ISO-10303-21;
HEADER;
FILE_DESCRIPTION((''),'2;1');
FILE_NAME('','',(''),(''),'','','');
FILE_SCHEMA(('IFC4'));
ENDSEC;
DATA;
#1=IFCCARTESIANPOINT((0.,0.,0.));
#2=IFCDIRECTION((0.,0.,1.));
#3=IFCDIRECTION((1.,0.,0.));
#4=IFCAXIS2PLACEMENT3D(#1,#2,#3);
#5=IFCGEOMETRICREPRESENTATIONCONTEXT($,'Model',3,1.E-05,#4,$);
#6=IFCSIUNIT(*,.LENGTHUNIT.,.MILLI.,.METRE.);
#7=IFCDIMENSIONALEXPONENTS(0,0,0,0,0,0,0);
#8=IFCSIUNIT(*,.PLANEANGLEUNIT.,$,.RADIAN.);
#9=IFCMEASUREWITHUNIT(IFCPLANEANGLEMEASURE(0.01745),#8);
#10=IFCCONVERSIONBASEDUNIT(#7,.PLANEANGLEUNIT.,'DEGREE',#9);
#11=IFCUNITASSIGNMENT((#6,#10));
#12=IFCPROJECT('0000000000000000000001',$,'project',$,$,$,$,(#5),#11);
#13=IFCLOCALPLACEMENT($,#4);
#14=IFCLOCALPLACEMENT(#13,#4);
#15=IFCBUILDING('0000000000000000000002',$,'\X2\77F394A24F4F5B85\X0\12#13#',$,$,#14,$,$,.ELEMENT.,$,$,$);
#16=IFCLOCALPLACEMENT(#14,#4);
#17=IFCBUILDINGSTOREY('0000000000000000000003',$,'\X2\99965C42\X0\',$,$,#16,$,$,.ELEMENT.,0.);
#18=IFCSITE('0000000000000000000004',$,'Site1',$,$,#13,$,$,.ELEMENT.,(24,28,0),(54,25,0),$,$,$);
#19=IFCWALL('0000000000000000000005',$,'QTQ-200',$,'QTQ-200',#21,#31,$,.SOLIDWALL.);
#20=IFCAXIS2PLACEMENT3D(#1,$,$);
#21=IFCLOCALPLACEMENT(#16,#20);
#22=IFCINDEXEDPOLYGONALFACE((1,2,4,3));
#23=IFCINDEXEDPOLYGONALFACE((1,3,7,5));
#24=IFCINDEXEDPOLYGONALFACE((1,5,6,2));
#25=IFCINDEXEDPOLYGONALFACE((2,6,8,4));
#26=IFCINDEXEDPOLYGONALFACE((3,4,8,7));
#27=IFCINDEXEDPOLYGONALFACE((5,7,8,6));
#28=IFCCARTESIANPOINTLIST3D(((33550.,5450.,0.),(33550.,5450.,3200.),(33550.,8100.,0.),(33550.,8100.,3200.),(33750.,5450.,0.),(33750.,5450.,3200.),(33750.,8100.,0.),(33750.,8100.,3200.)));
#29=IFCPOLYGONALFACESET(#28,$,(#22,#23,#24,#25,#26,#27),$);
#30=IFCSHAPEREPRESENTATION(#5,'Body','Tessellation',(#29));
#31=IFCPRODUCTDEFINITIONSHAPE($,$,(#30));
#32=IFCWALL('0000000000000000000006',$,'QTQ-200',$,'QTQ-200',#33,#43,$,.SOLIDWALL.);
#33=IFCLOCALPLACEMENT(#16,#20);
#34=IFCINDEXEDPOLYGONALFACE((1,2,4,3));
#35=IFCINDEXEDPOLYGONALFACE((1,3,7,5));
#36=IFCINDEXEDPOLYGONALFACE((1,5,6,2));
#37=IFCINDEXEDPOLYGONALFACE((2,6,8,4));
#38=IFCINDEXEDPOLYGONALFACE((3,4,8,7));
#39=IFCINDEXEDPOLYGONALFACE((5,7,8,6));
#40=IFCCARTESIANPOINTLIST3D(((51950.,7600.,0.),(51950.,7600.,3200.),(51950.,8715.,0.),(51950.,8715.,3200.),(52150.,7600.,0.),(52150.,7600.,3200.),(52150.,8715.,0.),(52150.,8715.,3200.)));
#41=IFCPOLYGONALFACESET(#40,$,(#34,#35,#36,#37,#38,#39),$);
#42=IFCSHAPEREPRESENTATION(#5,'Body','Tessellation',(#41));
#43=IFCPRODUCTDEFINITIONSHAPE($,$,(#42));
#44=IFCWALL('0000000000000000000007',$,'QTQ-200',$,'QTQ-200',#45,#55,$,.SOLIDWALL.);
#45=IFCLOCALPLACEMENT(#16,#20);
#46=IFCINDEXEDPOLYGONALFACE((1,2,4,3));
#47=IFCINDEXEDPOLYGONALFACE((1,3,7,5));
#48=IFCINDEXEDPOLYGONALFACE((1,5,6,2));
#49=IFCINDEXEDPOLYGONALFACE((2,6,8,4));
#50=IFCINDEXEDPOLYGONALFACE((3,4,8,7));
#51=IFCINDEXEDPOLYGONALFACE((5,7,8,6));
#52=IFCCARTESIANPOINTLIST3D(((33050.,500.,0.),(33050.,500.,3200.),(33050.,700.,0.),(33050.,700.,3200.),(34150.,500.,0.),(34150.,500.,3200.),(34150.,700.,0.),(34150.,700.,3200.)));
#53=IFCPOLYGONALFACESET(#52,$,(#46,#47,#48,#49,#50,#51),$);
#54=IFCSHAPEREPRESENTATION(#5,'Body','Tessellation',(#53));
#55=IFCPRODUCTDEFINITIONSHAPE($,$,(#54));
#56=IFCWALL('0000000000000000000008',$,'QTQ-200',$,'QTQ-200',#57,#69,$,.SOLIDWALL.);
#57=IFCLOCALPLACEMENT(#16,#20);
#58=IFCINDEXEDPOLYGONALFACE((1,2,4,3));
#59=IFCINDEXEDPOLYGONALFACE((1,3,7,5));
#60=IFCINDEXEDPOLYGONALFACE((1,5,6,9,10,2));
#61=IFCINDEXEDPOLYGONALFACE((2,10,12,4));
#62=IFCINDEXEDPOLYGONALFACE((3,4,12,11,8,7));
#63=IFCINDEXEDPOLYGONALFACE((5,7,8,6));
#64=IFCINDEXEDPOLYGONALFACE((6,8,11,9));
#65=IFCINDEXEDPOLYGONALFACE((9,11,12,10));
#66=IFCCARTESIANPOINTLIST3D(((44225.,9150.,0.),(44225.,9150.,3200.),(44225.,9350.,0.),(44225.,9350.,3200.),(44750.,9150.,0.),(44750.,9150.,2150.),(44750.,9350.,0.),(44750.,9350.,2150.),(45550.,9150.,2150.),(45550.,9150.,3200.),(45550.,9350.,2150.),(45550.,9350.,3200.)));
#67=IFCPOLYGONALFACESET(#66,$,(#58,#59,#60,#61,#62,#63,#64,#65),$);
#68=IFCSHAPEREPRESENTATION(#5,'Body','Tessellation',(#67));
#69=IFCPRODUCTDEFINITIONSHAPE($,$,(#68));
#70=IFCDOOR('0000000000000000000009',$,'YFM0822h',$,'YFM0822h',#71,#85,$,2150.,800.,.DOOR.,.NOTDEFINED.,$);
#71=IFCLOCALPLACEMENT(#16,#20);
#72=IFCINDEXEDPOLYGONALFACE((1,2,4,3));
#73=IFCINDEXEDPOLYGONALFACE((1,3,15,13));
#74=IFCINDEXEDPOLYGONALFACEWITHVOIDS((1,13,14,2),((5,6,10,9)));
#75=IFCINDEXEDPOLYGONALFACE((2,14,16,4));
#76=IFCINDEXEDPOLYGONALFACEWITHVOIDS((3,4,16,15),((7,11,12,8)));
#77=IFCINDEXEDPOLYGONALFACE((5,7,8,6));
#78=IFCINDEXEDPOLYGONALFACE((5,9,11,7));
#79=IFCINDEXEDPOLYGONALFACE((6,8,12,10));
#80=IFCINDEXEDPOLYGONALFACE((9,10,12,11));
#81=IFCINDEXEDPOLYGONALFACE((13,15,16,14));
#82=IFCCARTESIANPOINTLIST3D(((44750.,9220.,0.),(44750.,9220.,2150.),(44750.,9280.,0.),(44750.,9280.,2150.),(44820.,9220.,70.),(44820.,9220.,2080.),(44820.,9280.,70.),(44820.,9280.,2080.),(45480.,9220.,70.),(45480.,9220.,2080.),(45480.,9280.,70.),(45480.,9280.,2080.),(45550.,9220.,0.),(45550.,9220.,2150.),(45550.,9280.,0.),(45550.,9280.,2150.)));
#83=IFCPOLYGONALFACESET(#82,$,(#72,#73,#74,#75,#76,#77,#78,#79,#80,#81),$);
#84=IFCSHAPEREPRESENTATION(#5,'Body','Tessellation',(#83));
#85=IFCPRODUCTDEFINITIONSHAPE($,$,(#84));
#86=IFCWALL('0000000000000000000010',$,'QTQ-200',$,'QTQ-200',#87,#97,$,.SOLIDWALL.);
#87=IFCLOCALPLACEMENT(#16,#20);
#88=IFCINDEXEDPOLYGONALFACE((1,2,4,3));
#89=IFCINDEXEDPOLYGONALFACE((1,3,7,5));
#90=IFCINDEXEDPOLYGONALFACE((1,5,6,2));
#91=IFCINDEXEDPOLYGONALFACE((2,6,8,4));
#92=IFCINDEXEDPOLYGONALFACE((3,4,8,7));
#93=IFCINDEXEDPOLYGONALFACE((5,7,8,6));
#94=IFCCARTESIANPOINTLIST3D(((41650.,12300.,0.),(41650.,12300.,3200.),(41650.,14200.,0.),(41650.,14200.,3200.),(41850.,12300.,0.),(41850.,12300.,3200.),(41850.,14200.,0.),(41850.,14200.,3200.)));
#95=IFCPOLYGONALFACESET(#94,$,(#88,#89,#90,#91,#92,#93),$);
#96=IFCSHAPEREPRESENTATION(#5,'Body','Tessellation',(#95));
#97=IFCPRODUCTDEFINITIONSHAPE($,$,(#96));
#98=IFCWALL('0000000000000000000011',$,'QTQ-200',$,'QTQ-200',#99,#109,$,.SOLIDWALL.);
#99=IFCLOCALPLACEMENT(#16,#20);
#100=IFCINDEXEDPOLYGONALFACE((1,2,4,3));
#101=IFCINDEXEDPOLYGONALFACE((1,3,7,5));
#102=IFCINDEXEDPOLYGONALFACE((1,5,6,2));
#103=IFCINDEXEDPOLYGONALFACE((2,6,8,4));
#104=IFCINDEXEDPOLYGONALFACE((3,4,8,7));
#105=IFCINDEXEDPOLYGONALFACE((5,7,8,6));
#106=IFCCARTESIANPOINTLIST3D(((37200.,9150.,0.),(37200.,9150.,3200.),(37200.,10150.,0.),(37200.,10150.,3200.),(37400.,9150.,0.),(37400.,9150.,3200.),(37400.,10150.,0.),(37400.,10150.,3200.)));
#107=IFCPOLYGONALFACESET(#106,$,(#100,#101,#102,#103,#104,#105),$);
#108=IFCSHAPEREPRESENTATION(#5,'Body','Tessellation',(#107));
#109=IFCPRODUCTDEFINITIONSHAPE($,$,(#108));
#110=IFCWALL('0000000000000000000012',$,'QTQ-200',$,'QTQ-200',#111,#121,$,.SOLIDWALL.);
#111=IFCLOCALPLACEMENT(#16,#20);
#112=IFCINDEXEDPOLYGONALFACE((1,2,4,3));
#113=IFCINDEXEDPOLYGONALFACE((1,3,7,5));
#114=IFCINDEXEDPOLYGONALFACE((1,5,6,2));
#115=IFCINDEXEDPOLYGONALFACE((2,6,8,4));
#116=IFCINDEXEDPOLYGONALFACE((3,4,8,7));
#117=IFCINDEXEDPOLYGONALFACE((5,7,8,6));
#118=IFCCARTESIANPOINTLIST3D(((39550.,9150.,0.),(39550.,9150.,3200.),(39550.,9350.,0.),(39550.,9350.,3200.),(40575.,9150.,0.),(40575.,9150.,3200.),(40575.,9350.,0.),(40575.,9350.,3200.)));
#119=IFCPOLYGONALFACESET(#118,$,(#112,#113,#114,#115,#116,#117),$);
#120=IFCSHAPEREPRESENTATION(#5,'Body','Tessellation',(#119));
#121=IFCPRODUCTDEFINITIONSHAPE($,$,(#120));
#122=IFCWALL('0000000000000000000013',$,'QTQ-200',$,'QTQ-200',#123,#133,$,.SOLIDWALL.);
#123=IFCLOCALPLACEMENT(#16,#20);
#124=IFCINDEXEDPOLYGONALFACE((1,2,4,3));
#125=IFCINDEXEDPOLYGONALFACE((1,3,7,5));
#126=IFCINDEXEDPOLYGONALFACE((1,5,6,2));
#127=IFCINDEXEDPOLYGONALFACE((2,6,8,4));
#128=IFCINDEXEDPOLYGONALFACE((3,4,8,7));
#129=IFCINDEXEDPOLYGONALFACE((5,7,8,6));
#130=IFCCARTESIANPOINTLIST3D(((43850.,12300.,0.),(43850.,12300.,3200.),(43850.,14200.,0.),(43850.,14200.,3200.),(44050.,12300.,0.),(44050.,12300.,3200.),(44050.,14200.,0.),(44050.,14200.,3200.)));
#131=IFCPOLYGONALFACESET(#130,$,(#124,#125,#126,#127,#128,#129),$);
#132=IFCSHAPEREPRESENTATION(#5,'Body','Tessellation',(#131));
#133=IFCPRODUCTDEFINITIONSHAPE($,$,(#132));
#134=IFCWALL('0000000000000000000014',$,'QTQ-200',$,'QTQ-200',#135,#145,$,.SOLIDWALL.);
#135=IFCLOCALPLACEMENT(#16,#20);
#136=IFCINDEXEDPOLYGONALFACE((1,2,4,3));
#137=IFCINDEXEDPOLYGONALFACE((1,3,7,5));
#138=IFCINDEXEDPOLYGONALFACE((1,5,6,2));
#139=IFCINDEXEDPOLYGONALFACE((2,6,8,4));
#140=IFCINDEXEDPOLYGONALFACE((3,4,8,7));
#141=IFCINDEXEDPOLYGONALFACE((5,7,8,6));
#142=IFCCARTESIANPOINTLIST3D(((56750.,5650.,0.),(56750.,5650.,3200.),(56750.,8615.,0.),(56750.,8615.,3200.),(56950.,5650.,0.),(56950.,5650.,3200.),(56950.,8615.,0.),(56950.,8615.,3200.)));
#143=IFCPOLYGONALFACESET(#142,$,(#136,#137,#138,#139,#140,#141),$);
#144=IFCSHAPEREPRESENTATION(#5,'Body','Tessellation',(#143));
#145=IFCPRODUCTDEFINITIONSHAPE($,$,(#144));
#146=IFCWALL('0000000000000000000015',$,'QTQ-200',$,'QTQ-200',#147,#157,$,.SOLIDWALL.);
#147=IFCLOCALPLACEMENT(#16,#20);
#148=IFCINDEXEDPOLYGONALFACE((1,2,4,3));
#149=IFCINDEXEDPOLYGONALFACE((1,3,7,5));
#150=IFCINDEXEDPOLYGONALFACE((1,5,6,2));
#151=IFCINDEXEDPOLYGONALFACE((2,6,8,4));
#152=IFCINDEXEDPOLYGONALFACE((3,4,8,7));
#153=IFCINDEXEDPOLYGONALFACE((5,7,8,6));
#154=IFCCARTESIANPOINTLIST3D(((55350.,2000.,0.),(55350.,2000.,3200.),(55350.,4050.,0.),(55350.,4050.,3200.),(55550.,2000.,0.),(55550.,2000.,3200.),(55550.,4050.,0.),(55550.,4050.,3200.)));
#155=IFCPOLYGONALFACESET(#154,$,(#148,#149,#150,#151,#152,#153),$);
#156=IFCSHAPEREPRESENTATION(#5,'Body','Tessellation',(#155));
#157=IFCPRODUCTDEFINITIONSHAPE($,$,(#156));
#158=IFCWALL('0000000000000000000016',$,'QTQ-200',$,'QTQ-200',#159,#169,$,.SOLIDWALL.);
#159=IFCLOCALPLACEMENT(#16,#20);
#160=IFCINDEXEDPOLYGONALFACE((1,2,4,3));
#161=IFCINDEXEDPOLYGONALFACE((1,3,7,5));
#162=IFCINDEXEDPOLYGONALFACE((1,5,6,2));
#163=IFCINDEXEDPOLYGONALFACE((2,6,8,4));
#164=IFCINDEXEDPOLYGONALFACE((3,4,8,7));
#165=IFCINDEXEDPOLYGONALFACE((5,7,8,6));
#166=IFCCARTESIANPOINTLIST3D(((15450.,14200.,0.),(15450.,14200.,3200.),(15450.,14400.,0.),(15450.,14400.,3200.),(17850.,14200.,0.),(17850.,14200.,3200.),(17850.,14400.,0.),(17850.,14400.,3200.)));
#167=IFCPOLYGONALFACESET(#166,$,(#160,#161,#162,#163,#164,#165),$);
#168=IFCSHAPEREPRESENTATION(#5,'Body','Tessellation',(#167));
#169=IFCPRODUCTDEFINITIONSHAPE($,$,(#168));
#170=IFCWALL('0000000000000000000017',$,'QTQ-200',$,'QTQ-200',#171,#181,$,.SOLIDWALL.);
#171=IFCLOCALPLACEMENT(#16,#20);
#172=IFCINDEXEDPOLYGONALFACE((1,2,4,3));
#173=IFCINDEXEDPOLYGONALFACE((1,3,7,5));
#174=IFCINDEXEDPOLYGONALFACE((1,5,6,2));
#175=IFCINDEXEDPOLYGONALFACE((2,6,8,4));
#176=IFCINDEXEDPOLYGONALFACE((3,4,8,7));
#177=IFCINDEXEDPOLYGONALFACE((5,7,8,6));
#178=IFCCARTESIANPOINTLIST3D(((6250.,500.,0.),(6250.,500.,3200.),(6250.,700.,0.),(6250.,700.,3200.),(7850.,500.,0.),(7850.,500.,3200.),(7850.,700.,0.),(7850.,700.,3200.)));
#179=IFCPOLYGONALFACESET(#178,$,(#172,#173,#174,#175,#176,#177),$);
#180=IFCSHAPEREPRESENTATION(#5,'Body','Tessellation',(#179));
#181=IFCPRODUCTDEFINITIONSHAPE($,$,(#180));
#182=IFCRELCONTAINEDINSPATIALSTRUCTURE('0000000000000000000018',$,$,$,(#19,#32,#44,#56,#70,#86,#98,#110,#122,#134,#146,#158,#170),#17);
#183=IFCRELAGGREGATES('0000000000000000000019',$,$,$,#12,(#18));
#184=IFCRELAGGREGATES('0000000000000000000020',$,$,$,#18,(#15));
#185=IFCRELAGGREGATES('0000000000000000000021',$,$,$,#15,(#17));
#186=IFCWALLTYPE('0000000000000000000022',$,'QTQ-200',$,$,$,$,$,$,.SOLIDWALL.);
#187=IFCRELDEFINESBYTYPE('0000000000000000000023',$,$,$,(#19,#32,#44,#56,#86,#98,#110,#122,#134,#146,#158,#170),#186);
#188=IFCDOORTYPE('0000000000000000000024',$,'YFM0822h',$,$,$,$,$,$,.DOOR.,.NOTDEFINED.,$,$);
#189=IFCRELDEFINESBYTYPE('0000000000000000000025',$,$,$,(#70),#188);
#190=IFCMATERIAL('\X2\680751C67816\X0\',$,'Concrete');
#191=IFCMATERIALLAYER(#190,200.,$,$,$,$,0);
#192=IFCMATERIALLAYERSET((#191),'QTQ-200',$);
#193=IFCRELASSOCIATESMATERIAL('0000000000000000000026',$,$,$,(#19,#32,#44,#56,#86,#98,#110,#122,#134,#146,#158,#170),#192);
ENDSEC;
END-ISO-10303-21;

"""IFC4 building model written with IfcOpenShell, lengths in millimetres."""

from ifc_helpers import new_model, entity, si_unit, converted_unit, frame, origin_with_axes, place, context, project, spatial, polyline, outline, extrude, material, layer, layer_set, type_object, element, fill, save


model = new_model("IFC4")

# Units and contexts
model_context = context("Model", 3, precision=1e-05, world=origin_with_axes())
ifc_project = project(units=[si_unit("LENGTHUNIT", "METRE", prefix="MILLI"), converted_unit("PLANEANGLEUNIT", "DEGREE", entity("IfcPlaneAngleMeasure", 0.01745), si_unit("PLANEANGLEUNIT", "RADIAN"), dimensions=[0, 0, 0, 0, 0, 0, 0])], contexts=[model_context])

# Site, building, storey
site_placement = place(None, origin_with_axes())
site = spatial("IfcSite", under=ifc_project, at=site_placement, Name="Site1", CompositionType="ELEMENT", RefLatitude=(24, 28, 0), RefLongitude=(54, 25, 0))
building_placement = place(site_placement, origin_with_axes())
building = spatial("IfcBuilding", under=site, at=building_placement, Name="石钢住宅12#13#", CompositionType="ELEMENT")
storey_placement = place(building_placement, origin_with_axes())
storey = spatial("IfcBuildingStorey", under=building, at=storey_placement, Name="首层", CompositionType="ELEMENT", Elevation=0.0)

# Walls
ifc_material = material(Name="标准砖", Category="Concrete")
ifc_layer = layer(ifc_material, 200.0, Priority=0)
ifc_layer_set = layer_set([ifc_layer], Name="QTQ-200")
wall_type = type_object("IfcWallType", Name="QTQ-200", PredefinedType="SOLIDWALL")
wall_1_placement = place(storey_placement, origin_with_axes())
element("IfcWall", 1, at=wall_1_placement, inside=storey, type_object=wall_type, material=ifc_layer_set, Name="QTQ-200", ObjectType="QTQ-200", PredefinedType="SOLIDWALL", context=model_context, shape_type="SweptSolid", body=[
    extrude(outline(polyline([(0.0, 0.0), (3200.0, 0.0), (3200.0, 2650.0), (0.0, 2650.0), (0.0, 0.0)])), frame((33750.0, 8100.0, 3200.0), z_axis=(-1.0, 0.0, 0.0), x_axis=(0.0, 0.0, -1.0)), (0.0, 0.0, 1.0), 200.0),
])
wall_2_placement = place(storey_placement, origin_with_axes())
element("IfcWall", 2, at=wall_2_placement, inside=storey, type_object=wall_type, material=ifc_layer_set, Name="QTQ-200", ObjectType="QTQ-200", PredefinedType="SOLIDWALL", context=model_context, shape_type="SweptSolid", body=[
    extrude(outline(polyline([(0.0, 0.0), (3200.0, 0.0), (3200.0, 1115.0), (0.0, 1115.0), (0.0, 0.0)])), frame((52150.0, 8715.0, 3200.0), z_axis=(-1.0, 0.0, 0.0), x_axis=(0.0, 0.0, -1.0)), (0.0, 0.0, 1.0), 200.0),
])
wall_3_placement = place(storey_placement, origin_with_axes())
element("IfcWall", 3, at=wall_3_placement, inside=storey, type_object=wall_type, material=ifc_layer_set, Name="QTQ-200", ObjectType="QTQ-200", PredefinedType="SOLIDWALL", context=model_context, shape_type="SweptSolid", body=[
    extrude(outline(polyline([(0.0, 0.0), (3200.0, 0.0), (3200.0, 1100.0), (0.0, 1100.0), (0.0, 0.0)])), frame((34150.0, 500.0, 3200.0), z_axis=(0.0, 1.0, 0.0), x_axis=(0.0, 0.0, -1.0)), (0.0, 0.0, 1.0), 200.0),
])

# Wall, opening, door
wall_4_placement = place(storey_placement, origin_with_axes())
wall_4 = element("IfcWall", 4, at=wall_4_placement, inside=storey, type_object=wall_type, material=ifc_layer_set, Name="QTQ-200", ObjectType="QTQ-200", PredefinedType="SOLIDWALL", context=model_context, shape_type="SweptSolid", body=[
    extrude(outline(polyline([(0.0, 0.0), (3200.0, 0.0), (3200.0, 1325.0), (0.0, 1325.0), (0.0, 0.0)])), frame((45550.0, 9150.0, 3200.0), z_axis=(0.0, 1.0, 0.0), x_axis=(0.0, 0.0, -1.0)), (0.0, 0.0, 1.0), 200.0),
])
opening_1_placement = place(storey_placement, origin_with_axes())
opening_1 = element("IfcOpeningElement", 5, at=opening_1_placement, cuts=wall_4, PredefinedType="OPENING", context=model_context, shape_type="SweptSolid", body=[
    extrude(outline(polyline([(0.0, 0.0), (800.0, 0.0), (800.0, 2150.0), (0.0, 2150.0), (0.0, 0.0)])), frame((45550.0, 8150.0, 0.0), z_axis=(0.0, 1.0, 0.0), x_axis=(-1.0, 0.0, 0.0)), (0.0, 0.0, 1.0), 2200.0),
])
door_type_1 = type_object("IfcDoorType", Name="YFM0822h", OperationType="NOTDEFINED", PredefinedType="DOOR")
door_1_placement = place(storey_placement, origin_with_axes())
door_1 = element("IfcDoor", 6, at=door_1_placement, inside=storey, type_object=door_type_1, Name="YFM0822h", ObjectType="YFM0822h", OperationType="NOTDEFINED", OverallHeight=2150.0, OverallWidth=800.0, PredefinedType="DOOR", context=model_context, shape_type="SweptSolid", body=[
    extrude(outline(polyline([(-400.0, -1075.0), (400.0, -1075.0), (400.0, 1075.0), (-400.0, 1075.0), (-400.0, -1075.0)]), holes=[polyline([(-330.0, -1005.0), (-330.0, 1005.0), (330.0, 1005.0), (330.0, -1005.0), (-330.0, -1005.0)])]), frame((45150.0, 9220.0, 1075.0), z_axis=(0.0, 1.0, 0.0), x_axis=(-1.0, 0.0, 0.0)), (0.0, 0.0, 1.0), 60.0),
])
fill(opening_1, door_1)

# Walls
wall_5_placement = place(storey_placement, origin_with_axes())
element("IfcWall", 7, at=wall_5_placement, inside=storey, type_object=wall_type, material=ifc_layer_set, Name="QTQ-200", ObjectType="QTQ-200", PredefinedType="SOLIDWALL", context=model_context, shape_type="SweptSolid", body=[
    extrude(outline(polyline([(0.0, 0.0), (3200.0, 0.0), (3200.0, 1900.0), (0.0, 1900.0), (0.0, 0.0)])), frame((41650.0, 12300.0, 3200.0), z_axis=(1.0, 0.0, 0.0), x_axis=(0.0, 0.0, -1.0)), (0.0, 0.0, 1.0), 200.0),
])
wall_6_placement = place(storey_placement, origin_with_axes())
element("IfcWall", 8, at=wall_6_placement, inside=storey, type_object=wall_type, material=ifc_layer_set, Name="QTQ-200", ObjectType="QTQ-200", PredefinedType="SOLIDWALL", context=model_context, shape_type="SweptSolid", body=[
    extrude(outline(polyline([(0.0, 0.0), (3200.0, 0.0), (3200.0, 1000.0), (0.0, 1000.0), (0.0, 0.0)])), frame((37400.0, 10150.0, 3200.0), z_axis=(-1.0, 0.0, 0.0), x_axis=(0.0, 0.0, -1.0)), (0.0, 0.0, 1.0), 200.0),
])
wall_7_placement = place(storey_placement, origin_with_axes())
element("IfcWall", 9, at=wall_7_placement, inside=storey, type_object=wall_type, material=ifc_layer_set, Name="QTQ-200", ObjectType="QTQ-200", PredefinedType="SOLIDWALL", context=model_context, shape_type="SweptSolid", body=[
    extrude(outline(polyline([(0.0, 0.0), (3200.0, 0.0), (3200.0, 1025.0), (0.0, 1025.0), (0.0, 0.0)])), frame((40575.0, 9150.0, 3200.0), z_axis=(0.0, 1.0, 0.0), x_axis=(0.0, 0.0, -1.0)), (0.0, 0.0, 1.0), 200.0),
])
wall_8_placement = place(storey_placement, origin_with_axes())
element("IfcWall", 10, at=wall_8_placement, inside=storey, type_object=wall_type, material=ifc_layer_set, Name="QTQ-200", ObjectType="QTQ-200", PredefinedType="SOLIDWALL", context=model_context, shape_type="SweptSolid", body=[
    extrude(outline(polyline([(0.0, 0.0), (3200.0, 0.0), (3200.0, 1900.0), (0.0, 1900.0), (0.0, 0.0)])), frame((43850.0, 12300.0, 3200.0), z_axis=(1.0, 0.0, 0.0), x_axis=(0.0, 0.0, -1.0)), (0.0, 0.0, 1.0), 200.0),
])
wall_9_placement = place(storey_placement, origin_with_axes())
element("IfcWall", 11, at=wall_9_placement, inside=storey, type_object=wall_type, material=ifc_layer_set, Name="QTQ-200", ObjectType="QTQ-200", PredefinedType="SOLIDWALL", context=model_context, shape_type="SweptSolid", body=[
    extrude(outline(polyline([(0.0, 0.0), (3200.0, 0.0), (3200.0, 2965.0), (0.0, 2965.0), (0.0, 0.0)])), frame((56950.0, 8615.0, 3200.0), z_axis=(-1.0, 0.0, 0.0), x_axis=(0.0, 0.0, -1.0)), (0.0, 0.0, 1.0), 200.0),
])
wall_10_placement = place(storey_placement, origin_with_axes())
element("IfcWall", 12, at=wall_10_placement, inside=storey, type_object=wall_type, material=ifc_layer_set, Name="QTQ-200", ObjectType="QTQ-200", PredefinedType="SOLIDWALL", context=model_context, shape_type="SweptSolid", body=[
    extrude(outline(polyline([(0.0, 0.0), (3200.0, 0.0), (3200.0, 2050.0), (0.0, 2050.0), (0.0, 0.0)])), frame((55350.0, 2000.0, 3200.0), z_axis=(1.0, 0.0, 0.0), x_axis=(0.0, 0.0, -1.0)), (0.0, 0.0, 1.0), 200.0),
])
wall_11_placement = place(storey_placement, origin_with_axes())
element("IfcWall", 13, at=wall_11_placement, inside=storey, type_object=wall_type, material=ifc_layer_set, Name="QTQ-200", ObjectType="QTQ-200", PredefinedType="SOLIDWALL", context=model_context, shape_type="SweptSolid", body=[
    extrude(outline(polyline([(0.0, 0.0), (3200.0, 0.0), (3200.0, 2400.0), (0.0, 2400.0), (0.0, 0.0)])), frame((15450.0, 14400.0, 3200.0), z_axis=(0.0, -1.0, 0.0), x_axis=(0.0, 0.0, -1.0)), (0.0, 0.0, 1.0), 200.0),
])
wall_12_placement = place(storey_placement, origin_with_axes())
element("IfcWall", 14, at=wall_12_placement, inside=storey, type_object=wall_type, material=ifc_layer_set, Name="QTQ-200", ObjectType="QTQ-200", PredefinedType="SOLIDWALL", context=model_context, shape_type="SweptSolid", body=[
    extrude(outline(polyline([(0.0, 0.0), (3200.0, 0.0), (3200.0, 1600.0), (0.0, 1600.0), (0.0, 0.0)])), frame((6250.0, 700.0, 3200.0), z_axis=(0.0, -1.0, 0.0), x_axis=(0.0, 0.0, -1.0)), (0.0, 0.0, 1.0), 200.0),
])

save(model, "model.ifc")
